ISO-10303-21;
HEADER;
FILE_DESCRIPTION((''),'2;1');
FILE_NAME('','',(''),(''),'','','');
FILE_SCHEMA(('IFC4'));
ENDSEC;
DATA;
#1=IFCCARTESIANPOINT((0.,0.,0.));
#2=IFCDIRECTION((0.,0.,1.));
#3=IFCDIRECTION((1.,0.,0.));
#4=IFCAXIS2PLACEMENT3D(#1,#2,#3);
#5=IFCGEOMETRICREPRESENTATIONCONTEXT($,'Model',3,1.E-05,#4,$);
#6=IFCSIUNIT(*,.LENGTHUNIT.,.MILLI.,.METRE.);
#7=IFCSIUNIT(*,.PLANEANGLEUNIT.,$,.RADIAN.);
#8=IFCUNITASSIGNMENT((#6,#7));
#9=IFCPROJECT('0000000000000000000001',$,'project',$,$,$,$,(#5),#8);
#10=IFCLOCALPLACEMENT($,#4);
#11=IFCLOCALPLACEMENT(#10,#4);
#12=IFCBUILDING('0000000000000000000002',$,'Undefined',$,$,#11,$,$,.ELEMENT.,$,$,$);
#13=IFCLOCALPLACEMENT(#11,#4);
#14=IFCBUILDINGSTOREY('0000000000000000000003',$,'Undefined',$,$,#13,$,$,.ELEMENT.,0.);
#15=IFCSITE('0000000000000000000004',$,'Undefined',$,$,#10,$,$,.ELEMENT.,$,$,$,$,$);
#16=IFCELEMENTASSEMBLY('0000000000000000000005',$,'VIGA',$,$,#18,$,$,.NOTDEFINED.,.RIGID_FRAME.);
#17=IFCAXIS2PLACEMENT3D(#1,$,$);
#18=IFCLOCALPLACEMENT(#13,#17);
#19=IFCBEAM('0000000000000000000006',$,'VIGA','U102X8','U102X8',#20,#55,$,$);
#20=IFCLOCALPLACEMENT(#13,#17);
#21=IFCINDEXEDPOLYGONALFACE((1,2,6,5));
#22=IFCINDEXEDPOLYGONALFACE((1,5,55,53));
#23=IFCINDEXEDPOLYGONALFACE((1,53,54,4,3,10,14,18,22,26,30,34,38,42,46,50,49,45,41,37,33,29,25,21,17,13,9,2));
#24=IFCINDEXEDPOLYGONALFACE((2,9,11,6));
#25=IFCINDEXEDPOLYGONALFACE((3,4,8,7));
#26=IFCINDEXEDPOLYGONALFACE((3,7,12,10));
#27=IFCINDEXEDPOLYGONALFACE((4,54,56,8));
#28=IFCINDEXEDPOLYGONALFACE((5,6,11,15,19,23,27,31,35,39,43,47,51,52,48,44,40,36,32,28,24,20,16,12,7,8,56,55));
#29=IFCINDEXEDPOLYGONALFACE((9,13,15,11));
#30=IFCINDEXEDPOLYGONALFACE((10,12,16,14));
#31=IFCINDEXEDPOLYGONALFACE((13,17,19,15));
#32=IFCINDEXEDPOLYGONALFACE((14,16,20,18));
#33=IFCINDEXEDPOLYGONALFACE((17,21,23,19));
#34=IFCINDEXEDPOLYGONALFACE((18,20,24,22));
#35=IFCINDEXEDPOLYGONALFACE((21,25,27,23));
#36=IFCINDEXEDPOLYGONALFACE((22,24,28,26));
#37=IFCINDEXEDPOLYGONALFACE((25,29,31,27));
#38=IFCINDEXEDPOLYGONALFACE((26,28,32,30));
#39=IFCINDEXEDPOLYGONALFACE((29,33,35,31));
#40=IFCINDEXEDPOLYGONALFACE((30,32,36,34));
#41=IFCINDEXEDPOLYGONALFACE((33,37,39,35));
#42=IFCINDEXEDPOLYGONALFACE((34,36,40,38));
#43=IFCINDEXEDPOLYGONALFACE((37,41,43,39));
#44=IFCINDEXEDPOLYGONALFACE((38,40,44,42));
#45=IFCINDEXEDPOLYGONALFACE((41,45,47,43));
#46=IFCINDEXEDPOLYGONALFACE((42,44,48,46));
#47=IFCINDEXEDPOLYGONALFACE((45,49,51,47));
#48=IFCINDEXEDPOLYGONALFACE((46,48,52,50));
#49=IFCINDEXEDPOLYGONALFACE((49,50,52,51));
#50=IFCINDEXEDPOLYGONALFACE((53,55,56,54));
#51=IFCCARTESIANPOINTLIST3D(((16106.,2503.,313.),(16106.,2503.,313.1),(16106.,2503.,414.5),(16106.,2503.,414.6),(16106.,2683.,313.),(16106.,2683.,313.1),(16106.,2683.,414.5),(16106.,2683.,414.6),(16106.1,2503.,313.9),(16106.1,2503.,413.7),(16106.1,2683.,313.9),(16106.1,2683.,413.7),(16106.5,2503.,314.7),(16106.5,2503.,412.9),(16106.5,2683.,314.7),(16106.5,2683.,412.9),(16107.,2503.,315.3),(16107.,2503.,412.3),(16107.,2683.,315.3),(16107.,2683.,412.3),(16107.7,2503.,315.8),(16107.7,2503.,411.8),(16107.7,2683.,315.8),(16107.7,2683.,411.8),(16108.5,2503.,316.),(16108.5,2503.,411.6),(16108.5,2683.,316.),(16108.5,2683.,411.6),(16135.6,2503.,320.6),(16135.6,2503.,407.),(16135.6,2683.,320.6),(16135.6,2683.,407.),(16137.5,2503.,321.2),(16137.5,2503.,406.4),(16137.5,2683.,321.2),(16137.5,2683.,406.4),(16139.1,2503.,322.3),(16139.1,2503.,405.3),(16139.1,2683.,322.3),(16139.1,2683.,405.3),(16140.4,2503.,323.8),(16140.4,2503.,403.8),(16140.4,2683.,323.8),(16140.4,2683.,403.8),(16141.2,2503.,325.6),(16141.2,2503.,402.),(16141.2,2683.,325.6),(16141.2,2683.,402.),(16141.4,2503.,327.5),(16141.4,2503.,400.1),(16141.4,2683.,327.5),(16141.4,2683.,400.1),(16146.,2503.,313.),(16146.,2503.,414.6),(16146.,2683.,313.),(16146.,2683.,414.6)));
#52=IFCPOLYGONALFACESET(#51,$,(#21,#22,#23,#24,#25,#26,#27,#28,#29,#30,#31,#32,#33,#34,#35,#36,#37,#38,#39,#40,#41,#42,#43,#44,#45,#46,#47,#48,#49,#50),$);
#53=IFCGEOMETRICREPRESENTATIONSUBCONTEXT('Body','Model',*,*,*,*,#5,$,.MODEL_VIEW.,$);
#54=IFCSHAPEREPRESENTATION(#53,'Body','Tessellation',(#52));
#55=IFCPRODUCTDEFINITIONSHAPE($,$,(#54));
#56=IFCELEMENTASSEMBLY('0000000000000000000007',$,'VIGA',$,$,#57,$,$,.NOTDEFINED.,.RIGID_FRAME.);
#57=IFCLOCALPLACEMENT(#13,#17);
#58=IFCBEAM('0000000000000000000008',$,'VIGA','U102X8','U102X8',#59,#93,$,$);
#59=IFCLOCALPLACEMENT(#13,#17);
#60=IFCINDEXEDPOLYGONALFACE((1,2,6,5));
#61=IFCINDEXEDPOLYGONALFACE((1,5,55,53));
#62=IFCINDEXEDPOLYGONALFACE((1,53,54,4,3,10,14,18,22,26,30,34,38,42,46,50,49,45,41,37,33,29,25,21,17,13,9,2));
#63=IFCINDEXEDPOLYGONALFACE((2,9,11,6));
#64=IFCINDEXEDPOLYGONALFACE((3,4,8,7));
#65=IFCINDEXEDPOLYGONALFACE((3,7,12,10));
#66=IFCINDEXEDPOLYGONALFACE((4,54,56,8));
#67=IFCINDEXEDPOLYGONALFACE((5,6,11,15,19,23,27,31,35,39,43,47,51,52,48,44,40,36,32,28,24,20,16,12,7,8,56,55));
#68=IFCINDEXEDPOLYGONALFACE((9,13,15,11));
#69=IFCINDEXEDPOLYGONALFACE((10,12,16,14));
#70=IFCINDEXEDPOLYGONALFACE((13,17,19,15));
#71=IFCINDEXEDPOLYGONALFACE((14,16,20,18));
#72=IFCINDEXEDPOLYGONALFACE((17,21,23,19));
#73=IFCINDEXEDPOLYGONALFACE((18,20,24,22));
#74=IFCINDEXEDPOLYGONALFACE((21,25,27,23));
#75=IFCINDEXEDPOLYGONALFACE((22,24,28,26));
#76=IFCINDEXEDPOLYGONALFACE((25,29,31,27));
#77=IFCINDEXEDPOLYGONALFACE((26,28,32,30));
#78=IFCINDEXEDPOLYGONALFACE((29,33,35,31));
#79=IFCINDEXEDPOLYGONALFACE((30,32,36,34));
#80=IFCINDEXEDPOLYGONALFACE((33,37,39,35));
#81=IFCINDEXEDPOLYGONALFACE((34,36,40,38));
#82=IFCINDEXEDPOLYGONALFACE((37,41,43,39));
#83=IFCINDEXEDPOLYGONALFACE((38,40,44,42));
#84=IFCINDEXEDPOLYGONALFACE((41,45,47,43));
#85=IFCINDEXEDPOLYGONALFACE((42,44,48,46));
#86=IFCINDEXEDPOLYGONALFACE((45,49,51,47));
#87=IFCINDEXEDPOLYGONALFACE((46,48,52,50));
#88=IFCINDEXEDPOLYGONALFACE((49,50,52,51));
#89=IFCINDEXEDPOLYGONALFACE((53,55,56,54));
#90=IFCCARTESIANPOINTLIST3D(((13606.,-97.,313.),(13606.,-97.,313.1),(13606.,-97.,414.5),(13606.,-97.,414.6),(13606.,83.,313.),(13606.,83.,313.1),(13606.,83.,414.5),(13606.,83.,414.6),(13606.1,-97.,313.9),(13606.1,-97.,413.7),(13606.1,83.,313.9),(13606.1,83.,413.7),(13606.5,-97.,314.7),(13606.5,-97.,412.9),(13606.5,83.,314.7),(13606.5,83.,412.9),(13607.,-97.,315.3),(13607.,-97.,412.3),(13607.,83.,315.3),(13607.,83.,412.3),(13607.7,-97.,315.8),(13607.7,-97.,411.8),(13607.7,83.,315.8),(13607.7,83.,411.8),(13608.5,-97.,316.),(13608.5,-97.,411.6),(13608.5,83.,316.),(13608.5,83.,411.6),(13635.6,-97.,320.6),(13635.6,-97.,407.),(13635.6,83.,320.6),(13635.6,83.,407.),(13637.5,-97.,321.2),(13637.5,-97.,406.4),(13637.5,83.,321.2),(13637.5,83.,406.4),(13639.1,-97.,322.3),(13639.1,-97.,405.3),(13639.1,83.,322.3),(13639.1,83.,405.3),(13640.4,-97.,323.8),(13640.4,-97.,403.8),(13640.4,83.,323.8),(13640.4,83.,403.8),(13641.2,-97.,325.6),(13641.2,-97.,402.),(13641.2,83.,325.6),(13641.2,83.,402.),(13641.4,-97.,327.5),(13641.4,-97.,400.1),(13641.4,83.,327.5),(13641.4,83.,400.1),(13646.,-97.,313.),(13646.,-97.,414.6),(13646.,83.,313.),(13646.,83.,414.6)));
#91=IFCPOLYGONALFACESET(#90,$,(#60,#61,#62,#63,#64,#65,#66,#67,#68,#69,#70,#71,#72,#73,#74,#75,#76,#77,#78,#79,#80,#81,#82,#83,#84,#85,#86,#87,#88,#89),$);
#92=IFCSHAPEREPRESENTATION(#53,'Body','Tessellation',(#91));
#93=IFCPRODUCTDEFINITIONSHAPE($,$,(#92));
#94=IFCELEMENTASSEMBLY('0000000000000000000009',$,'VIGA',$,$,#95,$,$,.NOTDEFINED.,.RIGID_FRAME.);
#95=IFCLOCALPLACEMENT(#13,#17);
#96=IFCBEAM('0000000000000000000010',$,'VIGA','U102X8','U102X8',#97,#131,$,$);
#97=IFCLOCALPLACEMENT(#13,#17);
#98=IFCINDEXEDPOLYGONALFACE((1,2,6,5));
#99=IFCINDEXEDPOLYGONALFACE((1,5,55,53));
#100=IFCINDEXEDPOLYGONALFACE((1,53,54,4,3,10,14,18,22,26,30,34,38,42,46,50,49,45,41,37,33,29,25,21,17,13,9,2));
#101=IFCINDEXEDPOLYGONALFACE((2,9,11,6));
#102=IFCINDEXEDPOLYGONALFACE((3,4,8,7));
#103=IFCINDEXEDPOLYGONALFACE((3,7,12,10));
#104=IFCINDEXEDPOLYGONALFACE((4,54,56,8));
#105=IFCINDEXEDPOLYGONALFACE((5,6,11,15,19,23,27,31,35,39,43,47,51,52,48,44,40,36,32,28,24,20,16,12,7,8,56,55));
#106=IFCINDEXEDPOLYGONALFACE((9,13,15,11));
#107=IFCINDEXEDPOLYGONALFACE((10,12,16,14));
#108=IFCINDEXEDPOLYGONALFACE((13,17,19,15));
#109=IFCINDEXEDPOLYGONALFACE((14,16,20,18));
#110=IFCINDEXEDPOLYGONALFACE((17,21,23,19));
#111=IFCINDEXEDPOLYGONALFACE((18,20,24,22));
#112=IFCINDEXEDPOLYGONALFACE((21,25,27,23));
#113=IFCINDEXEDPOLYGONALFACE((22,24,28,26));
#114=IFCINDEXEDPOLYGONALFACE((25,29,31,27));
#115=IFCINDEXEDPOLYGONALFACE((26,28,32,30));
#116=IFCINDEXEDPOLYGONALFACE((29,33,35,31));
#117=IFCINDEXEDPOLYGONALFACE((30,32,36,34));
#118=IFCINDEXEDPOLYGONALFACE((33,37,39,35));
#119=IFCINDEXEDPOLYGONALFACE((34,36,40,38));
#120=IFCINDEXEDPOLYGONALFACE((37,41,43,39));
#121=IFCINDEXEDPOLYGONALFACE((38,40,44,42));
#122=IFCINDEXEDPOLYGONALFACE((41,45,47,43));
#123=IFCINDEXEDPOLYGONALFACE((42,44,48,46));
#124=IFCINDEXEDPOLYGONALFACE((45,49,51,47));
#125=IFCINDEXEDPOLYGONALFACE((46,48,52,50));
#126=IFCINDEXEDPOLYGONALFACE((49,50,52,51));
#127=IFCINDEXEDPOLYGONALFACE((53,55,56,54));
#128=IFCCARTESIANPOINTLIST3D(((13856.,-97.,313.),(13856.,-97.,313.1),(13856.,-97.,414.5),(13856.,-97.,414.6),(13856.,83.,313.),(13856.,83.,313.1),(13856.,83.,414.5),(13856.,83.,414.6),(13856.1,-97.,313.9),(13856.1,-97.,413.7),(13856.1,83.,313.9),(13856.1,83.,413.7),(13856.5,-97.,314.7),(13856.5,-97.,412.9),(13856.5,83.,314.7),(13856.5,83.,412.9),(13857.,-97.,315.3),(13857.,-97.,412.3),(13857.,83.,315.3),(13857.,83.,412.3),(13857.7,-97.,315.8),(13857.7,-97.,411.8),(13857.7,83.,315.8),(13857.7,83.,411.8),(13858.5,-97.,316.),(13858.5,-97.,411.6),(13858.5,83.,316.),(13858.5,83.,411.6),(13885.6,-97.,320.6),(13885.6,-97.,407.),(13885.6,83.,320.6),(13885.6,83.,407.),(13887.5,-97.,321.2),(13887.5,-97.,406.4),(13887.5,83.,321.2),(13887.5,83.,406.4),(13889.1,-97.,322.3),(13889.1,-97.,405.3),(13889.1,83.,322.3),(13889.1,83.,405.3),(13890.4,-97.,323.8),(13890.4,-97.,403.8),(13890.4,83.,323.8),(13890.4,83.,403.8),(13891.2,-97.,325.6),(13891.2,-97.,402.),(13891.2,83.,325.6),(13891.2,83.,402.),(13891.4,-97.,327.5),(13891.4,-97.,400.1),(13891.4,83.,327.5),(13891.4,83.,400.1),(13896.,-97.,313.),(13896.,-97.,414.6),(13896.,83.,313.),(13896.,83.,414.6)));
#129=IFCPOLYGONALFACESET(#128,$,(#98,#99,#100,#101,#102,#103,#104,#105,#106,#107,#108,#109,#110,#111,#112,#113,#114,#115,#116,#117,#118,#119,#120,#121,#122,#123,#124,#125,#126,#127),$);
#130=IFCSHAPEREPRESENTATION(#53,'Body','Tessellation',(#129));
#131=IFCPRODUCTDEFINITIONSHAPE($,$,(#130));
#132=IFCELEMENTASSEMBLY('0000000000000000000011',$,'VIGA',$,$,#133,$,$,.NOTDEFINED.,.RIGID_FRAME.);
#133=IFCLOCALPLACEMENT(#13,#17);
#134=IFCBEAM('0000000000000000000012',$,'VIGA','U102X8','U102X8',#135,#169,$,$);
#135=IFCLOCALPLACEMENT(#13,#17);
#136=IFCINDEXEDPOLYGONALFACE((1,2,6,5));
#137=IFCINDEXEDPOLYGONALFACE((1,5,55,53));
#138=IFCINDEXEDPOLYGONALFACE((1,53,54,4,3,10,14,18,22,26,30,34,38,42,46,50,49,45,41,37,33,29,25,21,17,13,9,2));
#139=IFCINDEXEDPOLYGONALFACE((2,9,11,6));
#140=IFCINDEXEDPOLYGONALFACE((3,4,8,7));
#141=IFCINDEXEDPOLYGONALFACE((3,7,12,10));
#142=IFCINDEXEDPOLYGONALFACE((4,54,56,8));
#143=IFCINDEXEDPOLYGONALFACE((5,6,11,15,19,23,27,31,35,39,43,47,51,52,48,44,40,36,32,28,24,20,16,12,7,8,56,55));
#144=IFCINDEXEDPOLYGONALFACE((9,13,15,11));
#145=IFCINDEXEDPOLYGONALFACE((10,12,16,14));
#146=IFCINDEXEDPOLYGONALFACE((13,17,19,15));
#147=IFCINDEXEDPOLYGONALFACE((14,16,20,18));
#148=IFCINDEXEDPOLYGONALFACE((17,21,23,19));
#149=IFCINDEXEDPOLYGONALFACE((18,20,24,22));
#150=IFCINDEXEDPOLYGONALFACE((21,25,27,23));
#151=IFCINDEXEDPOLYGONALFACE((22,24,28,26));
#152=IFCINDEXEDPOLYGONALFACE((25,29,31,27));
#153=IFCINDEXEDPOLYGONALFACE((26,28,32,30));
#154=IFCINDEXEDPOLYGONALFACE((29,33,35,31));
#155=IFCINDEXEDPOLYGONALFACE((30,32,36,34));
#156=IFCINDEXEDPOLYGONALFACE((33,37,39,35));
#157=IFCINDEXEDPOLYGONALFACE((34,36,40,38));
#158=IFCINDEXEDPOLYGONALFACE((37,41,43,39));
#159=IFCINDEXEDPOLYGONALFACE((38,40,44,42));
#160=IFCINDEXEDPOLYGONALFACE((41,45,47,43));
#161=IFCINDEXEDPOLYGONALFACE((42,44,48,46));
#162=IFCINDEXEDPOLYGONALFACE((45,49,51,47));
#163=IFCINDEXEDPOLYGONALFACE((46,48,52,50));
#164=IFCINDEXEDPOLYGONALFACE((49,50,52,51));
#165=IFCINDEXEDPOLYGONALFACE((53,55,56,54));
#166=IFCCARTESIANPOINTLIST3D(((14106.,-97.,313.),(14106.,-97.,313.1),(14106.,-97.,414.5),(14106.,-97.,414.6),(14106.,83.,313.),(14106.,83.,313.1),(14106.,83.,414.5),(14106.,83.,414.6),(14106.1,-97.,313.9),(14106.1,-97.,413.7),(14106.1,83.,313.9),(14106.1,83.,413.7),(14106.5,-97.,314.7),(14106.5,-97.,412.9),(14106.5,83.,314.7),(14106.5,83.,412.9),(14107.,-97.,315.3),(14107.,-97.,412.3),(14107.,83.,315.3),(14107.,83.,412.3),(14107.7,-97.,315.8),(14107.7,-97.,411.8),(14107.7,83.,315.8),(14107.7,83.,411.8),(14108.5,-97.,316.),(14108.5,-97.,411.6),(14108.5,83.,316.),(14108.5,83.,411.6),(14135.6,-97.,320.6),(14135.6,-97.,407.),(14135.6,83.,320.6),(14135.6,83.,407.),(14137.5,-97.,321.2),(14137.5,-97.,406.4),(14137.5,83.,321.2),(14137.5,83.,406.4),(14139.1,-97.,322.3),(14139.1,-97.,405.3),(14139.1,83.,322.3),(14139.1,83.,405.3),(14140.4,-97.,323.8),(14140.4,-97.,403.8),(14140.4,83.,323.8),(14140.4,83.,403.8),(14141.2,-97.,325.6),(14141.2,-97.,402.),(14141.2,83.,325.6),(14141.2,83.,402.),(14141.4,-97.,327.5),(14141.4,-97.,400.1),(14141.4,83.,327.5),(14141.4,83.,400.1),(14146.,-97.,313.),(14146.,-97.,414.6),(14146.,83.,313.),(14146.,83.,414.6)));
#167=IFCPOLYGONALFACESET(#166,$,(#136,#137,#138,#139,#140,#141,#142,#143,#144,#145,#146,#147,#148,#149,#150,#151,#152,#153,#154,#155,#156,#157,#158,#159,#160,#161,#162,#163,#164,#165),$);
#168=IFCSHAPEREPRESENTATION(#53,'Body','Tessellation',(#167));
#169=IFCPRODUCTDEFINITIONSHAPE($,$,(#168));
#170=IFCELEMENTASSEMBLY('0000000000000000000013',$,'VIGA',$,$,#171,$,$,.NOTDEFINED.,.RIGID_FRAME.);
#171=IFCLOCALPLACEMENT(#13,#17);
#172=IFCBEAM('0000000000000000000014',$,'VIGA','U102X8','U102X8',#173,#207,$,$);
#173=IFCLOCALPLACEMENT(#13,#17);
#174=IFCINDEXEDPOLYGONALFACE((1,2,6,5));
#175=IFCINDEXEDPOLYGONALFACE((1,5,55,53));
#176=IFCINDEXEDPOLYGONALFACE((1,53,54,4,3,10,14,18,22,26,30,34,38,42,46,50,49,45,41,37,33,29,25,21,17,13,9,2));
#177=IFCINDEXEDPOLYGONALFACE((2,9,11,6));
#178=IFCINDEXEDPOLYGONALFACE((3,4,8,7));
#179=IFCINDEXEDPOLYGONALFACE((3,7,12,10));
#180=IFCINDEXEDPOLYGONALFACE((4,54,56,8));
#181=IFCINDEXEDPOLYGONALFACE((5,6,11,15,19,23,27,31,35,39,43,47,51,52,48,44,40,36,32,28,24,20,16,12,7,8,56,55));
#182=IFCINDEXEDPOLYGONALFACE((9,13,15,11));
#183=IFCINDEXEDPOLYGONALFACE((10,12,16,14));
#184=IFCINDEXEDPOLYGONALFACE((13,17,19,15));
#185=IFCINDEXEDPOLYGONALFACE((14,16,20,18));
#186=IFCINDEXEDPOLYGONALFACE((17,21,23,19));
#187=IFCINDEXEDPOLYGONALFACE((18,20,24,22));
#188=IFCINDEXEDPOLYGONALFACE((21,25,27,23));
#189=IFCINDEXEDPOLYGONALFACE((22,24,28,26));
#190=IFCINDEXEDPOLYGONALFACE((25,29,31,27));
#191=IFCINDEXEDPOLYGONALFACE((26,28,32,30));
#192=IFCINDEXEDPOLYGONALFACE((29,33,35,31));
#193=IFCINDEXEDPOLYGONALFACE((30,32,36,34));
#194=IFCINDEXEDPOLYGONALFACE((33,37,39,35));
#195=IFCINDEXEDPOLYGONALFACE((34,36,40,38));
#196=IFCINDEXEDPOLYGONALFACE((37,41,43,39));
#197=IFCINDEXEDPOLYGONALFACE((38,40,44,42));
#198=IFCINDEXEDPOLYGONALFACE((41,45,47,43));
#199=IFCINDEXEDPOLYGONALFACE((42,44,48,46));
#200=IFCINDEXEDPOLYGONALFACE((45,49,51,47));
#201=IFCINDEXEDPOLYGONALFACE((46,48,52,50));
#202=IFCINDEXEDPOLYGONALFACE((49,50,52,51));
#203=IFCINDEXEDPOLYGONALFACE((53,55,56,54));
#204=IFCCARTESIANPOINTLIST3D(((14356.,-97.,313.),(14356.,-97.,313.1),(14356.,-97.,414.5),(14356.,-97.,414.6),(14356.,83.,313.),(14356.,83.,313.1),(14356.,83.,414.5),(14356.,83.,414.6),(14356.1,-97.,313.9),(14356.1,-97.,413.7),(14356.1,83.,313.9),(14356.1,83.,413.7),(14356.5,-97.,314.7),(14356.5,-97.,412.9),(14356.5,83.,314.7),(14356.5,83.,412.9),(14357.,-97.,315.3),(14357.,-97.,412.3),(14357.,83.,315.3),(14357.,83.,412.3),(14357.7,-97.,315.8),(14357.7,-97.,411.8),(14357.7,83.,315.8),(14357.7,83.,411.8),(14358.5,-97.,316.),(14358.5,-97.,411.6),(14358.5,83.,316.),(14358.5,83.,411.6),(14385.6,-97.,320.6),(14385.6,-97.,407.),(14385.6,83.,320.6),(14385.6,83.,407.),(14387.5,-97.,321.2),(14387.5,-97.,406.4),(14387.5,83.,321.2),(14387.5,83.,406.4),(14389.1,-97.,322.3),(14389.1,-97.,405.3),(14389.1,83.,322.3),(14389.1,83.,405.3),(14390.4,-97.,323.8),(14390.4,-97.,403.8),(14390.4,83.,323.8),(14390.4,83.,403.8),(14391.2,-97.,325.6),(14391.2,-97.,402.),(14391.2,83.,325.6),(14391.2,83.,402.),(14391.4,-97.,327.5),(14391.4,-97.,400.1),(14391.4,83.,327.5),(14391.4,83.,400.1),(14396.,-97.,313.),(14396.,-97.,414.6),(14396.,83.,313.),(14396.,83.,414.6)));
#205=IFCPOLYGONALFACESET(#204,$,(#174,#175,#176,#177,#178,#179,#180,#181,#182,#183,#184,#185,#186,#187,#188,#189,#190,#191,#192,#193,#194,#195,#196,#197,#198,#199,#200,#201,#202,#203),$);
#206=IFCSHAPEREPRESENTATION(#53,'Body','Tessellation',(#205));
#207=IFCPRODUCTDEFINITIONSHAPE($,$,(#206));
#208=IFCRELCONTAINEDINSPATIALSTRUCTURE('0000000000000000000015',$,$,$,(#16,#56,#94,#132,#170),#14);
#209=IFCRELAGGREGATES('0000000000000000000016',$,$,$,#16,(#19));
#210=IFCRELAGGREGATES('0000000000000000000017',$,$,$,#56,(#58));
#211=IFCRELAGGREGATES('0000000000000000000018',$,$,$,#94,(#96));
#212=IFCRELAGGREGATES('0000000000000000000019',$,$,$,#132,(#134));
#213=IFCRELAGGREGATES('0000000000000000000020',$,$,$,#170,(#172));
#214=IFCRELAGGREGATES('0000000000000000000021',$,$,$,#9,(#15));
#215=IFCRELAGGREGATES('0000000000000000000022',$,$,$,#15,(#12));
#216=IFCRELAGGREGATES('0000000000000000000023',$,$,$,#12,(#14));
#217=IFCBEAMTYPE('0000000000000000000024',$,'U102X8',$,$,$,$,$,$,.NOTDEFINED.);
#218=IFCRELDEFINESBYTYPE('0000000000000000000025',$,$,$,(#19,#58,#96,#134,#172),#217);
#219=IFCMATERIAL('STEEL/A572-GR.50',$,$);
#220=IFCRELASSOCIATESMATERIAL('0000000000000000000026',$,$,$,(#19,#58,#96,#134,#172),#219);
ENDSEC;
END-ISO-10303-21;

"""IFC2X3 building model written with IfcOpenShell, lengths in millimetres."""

from ifc_helpers import new_model, si_unit, frame, origin_with_axes, origin_2d_with_axis, place, context, subcontext, project, spatial, u_section, extrude, material, type_object, element, aggregate, save


model = new_model("IFC2X3")

# Units and contexts
model_context = context("Model", 3, precision=1e-05, world=origin_with_axes())
body_context = subcontext(model_context, "Body", "Model", "MODEL_VIEW")
ifc_project = project(units=[si_unit("LENGTHUNIT", "METRE", prefix="MILLI"), si_unit("PLANEANGLEUNIT", "RADIAN")], contexts=[model_context])

# Site, building, storey
site_placement = place(None, origin_with_axes())
site = spatial("IfcSite", under=ifc_project, at=site_placement, Name="Undefined", CompositionType="ELEMENT")
building_placement = place(site_placement, origin_with_axes())
building = spatial("IfcBuilding", under=site, at=building_placement, Name="Undefined", CompositionType="ELEMENT")
storey_placement = place(building_placement, origin_with_axes())
storey = spatial("IfcBuildingStorey", under=building, at=storey_placement, Name="Undefined", CompositionType="ELEMENT", Elevation=0.0)

# Element assemblies, beams
ifc_material = material(Name="STEEL/A572-GR.50")
beam_type = type_object("IfcBeamType", Name="U102X8", PredefinedType="NOTDEFINED")
assembly_1_placement = place(storey_placement, origin_with_axes())
assembly_1 = element("IfcElementAssembly", 1, at=assembly_1_placement, inside=storey, Name="VIGA", AssemblyPlace="NOTDEFINED", PredefinedType="RIGID_FRAME")
beam_1_placement = place(assembly_1_placement, frame((16126.0, 2683.0, 363.8), z_axis=(0.0, 0.0, 1.0), x_axis=(0.0, -1.0, 0.0)))
beam_1 = element("IfcBeam", 2, at=beam_1_placement, type_object=beam_type, material=ifc_material, Name="VIGA", Description="U102X8", ObjectType="U102X8", context=body_context, shape_type="SweptSolid", body=[
    extrude(u_section(Depth=101.6, FlangeWidth=40.0, WebThickness=4.6, FlangeThickness=6.0, FilletRadius=7.0, EdgeRadius=3.0, FlangeSlope=0.16839, at=origin_2d_with_axis()), frame((180.0, 0.0, 0.0), z_axis=(-1.0, 0.0, 0.0), x_axis=(0.0, -1.0, 0.0)), (0.0, 0.0, 1.0), 180.0),
])
aggregate(assembly_1, [beam_1])
assembly_2_placement = place(storey_placement, origin_with_axes())
assembly_2 = element("IfcElementAssembly", 3, at=assembly_2_placement, inside=storey, Name="VIGA", AssemblyPlace="NOTDEFINED", PredefinedType="RIGID_FRAME")
beam_2_placement = place(assembly_2_placement, frame((13626.0, 83.0, 363.8), z_axis=(0.0, 0.0, 1.0), x_axis=(0.0, -1.0, 0.0)))
beam_2 = element("IfcBeam", 4, at=beam_2_placement, type_object=beam_type, material=ifc_material, Name="VIGA", Description="U102X8", ObjectType="U102X8", context=body_context, shape_type="SweptSolid", body=[
    extrude(u_section(Depth=101.6, FlangeWidth=40.0, WebThickness=4.6, FlangeThickness=6.0, FilletRadius=7.0, EdgeRadius=3.0, FlangeSlope=0.16839, at=origin_2d_with_axis()), frame((180.0, 0.0, 0.0), z_axis=(-1.0, 0.0, 0.0), x_axis=(0.0, -1.0, 0.0)), (0.0, 0.0, 1.0), 180.0),
])
aggregate(assembly_2, [beam_2])
assembly_3_placement = place(storey_placement, origin_with_axes())
assembly_3 = element("IfcElementAssembly", 5, at=assembly_3_placement, inside=storey, Name="VIGA", AssemblyPlace="NOTDEFINED", PredefinedType="RIGID_FRAME")
beam_3_placement = place(assembly_3_placement, frame((13876.0, 83.0, 363.8), z_axis=(0.0, 0.0, 1.0), x_axis=(0.0, -1.0, 0.0)))
beam_3 = element("IfcBeam", 6, at=beam_3_placement, type_object=beam_type, material=ifc_material, Name="VIGA", Description="U102X8", ObjectType="U102X8", context=body_context, shape_type="SweptSolid", body=[
    extrude(u_section(Depth=101.6, FlangeWidth=40.0, WebThickness=4.6, FlangeThickness=6.0, FilletRadius=7.0, EdgeRadius=3.0, FlangeSlope=0.16839, at=origin_2d_with_axis()), frame((180.0, 0.0, 0.0), z_axis=(-1.0, 0.0, 0.0), x_axis=(0.0, -1.0, 0.0)), (0.0, 0.0, 1.0), 180.0),
])
aggregate(assembly_3, [beam_3])
assembly_4_placement = place(storey_placement, origin_with_axes())
assembly_4 = element("IfcElementAssembly", 7, at=assembly_4_placement, inside=storey, Name="VIGA", AssemblyPlace="NOTDEFINED", PredefinedType="RIGID_FRAME")
beam_4_placement = place(assembly_4_placement, frame((14126.0, 83.0, 363.8), z_axis=(0.0, 0.0, 1.0), x_axis=(0.0, -1.0, 0.0)))
beam_4 = element("IfcBeam", 8, at=beam_4_placement, type_object=beam_type, material=ifc_material, Name="VIGA", Description="U102X8", ObjectType="U102X8", context=body_context, shape_type="SweptSolid", body=[
    extrude(u_section(Depth=101.6, FlangeWidth=40.0, WebThickness=4.6, FlangeThickness=6.0, FilletRadius=7.0, EdgeRadius=3.0, FlangeSlope=0.16839, at=origin_2d_with_axis()), frame((180.0, 0.0, 0.0), z_axis=(-1.0, 0.0, 0.0), x_axis=(0.0, -1.0, 0.0)), (0.0, 0.0, 1.0), 180.0),
])
aggregate(assembly_4, [beam_4])
assembly_5_placement = place(storey_placement, origin_with_axes())
assembly_5 = element("IfcElementAssembly", 9, at=assembly_5_placement, inside=storey, Name="VIGA", AssemblyPlace="NOTDEFINED", PredefinedType="RIGID_FRAME")
beam_5_placement = place(assembly_5_placement, frame((14376.0, 83.0, 363.8), z_axis=(0.0, 0.0, 1.0), x_axis=(0.0, -1.0, 0.0)))
beam_5 = element("IfcBeam", 10, at=beam_5_placement, type_object=beam_type, material=ifc_material, Name="VIGA", Description="U102X8", ObjectType="U102X8", context=body_context, shape_type="SweptSolid", body=[
    extrude(u_section(Depth=101.6, FlangeWidth=40.0, WebThickness=4.6, FlangeThickness=6.0, FilletRadius=7.0, EdgeRadius=3.0, FlangeSlope=0.16839, at=origin_2d_with_axis()), frame((180.0, 0.0, 0.0), z_axis=(-1.0, 0.0, 0.0), x_axis=(0.0, -1.0, 0.0)), (0.0, 0.0, 1.0), 180.0),
])
aggregate(assembly_5, [beam_5])

save(model, "model.ifc")
